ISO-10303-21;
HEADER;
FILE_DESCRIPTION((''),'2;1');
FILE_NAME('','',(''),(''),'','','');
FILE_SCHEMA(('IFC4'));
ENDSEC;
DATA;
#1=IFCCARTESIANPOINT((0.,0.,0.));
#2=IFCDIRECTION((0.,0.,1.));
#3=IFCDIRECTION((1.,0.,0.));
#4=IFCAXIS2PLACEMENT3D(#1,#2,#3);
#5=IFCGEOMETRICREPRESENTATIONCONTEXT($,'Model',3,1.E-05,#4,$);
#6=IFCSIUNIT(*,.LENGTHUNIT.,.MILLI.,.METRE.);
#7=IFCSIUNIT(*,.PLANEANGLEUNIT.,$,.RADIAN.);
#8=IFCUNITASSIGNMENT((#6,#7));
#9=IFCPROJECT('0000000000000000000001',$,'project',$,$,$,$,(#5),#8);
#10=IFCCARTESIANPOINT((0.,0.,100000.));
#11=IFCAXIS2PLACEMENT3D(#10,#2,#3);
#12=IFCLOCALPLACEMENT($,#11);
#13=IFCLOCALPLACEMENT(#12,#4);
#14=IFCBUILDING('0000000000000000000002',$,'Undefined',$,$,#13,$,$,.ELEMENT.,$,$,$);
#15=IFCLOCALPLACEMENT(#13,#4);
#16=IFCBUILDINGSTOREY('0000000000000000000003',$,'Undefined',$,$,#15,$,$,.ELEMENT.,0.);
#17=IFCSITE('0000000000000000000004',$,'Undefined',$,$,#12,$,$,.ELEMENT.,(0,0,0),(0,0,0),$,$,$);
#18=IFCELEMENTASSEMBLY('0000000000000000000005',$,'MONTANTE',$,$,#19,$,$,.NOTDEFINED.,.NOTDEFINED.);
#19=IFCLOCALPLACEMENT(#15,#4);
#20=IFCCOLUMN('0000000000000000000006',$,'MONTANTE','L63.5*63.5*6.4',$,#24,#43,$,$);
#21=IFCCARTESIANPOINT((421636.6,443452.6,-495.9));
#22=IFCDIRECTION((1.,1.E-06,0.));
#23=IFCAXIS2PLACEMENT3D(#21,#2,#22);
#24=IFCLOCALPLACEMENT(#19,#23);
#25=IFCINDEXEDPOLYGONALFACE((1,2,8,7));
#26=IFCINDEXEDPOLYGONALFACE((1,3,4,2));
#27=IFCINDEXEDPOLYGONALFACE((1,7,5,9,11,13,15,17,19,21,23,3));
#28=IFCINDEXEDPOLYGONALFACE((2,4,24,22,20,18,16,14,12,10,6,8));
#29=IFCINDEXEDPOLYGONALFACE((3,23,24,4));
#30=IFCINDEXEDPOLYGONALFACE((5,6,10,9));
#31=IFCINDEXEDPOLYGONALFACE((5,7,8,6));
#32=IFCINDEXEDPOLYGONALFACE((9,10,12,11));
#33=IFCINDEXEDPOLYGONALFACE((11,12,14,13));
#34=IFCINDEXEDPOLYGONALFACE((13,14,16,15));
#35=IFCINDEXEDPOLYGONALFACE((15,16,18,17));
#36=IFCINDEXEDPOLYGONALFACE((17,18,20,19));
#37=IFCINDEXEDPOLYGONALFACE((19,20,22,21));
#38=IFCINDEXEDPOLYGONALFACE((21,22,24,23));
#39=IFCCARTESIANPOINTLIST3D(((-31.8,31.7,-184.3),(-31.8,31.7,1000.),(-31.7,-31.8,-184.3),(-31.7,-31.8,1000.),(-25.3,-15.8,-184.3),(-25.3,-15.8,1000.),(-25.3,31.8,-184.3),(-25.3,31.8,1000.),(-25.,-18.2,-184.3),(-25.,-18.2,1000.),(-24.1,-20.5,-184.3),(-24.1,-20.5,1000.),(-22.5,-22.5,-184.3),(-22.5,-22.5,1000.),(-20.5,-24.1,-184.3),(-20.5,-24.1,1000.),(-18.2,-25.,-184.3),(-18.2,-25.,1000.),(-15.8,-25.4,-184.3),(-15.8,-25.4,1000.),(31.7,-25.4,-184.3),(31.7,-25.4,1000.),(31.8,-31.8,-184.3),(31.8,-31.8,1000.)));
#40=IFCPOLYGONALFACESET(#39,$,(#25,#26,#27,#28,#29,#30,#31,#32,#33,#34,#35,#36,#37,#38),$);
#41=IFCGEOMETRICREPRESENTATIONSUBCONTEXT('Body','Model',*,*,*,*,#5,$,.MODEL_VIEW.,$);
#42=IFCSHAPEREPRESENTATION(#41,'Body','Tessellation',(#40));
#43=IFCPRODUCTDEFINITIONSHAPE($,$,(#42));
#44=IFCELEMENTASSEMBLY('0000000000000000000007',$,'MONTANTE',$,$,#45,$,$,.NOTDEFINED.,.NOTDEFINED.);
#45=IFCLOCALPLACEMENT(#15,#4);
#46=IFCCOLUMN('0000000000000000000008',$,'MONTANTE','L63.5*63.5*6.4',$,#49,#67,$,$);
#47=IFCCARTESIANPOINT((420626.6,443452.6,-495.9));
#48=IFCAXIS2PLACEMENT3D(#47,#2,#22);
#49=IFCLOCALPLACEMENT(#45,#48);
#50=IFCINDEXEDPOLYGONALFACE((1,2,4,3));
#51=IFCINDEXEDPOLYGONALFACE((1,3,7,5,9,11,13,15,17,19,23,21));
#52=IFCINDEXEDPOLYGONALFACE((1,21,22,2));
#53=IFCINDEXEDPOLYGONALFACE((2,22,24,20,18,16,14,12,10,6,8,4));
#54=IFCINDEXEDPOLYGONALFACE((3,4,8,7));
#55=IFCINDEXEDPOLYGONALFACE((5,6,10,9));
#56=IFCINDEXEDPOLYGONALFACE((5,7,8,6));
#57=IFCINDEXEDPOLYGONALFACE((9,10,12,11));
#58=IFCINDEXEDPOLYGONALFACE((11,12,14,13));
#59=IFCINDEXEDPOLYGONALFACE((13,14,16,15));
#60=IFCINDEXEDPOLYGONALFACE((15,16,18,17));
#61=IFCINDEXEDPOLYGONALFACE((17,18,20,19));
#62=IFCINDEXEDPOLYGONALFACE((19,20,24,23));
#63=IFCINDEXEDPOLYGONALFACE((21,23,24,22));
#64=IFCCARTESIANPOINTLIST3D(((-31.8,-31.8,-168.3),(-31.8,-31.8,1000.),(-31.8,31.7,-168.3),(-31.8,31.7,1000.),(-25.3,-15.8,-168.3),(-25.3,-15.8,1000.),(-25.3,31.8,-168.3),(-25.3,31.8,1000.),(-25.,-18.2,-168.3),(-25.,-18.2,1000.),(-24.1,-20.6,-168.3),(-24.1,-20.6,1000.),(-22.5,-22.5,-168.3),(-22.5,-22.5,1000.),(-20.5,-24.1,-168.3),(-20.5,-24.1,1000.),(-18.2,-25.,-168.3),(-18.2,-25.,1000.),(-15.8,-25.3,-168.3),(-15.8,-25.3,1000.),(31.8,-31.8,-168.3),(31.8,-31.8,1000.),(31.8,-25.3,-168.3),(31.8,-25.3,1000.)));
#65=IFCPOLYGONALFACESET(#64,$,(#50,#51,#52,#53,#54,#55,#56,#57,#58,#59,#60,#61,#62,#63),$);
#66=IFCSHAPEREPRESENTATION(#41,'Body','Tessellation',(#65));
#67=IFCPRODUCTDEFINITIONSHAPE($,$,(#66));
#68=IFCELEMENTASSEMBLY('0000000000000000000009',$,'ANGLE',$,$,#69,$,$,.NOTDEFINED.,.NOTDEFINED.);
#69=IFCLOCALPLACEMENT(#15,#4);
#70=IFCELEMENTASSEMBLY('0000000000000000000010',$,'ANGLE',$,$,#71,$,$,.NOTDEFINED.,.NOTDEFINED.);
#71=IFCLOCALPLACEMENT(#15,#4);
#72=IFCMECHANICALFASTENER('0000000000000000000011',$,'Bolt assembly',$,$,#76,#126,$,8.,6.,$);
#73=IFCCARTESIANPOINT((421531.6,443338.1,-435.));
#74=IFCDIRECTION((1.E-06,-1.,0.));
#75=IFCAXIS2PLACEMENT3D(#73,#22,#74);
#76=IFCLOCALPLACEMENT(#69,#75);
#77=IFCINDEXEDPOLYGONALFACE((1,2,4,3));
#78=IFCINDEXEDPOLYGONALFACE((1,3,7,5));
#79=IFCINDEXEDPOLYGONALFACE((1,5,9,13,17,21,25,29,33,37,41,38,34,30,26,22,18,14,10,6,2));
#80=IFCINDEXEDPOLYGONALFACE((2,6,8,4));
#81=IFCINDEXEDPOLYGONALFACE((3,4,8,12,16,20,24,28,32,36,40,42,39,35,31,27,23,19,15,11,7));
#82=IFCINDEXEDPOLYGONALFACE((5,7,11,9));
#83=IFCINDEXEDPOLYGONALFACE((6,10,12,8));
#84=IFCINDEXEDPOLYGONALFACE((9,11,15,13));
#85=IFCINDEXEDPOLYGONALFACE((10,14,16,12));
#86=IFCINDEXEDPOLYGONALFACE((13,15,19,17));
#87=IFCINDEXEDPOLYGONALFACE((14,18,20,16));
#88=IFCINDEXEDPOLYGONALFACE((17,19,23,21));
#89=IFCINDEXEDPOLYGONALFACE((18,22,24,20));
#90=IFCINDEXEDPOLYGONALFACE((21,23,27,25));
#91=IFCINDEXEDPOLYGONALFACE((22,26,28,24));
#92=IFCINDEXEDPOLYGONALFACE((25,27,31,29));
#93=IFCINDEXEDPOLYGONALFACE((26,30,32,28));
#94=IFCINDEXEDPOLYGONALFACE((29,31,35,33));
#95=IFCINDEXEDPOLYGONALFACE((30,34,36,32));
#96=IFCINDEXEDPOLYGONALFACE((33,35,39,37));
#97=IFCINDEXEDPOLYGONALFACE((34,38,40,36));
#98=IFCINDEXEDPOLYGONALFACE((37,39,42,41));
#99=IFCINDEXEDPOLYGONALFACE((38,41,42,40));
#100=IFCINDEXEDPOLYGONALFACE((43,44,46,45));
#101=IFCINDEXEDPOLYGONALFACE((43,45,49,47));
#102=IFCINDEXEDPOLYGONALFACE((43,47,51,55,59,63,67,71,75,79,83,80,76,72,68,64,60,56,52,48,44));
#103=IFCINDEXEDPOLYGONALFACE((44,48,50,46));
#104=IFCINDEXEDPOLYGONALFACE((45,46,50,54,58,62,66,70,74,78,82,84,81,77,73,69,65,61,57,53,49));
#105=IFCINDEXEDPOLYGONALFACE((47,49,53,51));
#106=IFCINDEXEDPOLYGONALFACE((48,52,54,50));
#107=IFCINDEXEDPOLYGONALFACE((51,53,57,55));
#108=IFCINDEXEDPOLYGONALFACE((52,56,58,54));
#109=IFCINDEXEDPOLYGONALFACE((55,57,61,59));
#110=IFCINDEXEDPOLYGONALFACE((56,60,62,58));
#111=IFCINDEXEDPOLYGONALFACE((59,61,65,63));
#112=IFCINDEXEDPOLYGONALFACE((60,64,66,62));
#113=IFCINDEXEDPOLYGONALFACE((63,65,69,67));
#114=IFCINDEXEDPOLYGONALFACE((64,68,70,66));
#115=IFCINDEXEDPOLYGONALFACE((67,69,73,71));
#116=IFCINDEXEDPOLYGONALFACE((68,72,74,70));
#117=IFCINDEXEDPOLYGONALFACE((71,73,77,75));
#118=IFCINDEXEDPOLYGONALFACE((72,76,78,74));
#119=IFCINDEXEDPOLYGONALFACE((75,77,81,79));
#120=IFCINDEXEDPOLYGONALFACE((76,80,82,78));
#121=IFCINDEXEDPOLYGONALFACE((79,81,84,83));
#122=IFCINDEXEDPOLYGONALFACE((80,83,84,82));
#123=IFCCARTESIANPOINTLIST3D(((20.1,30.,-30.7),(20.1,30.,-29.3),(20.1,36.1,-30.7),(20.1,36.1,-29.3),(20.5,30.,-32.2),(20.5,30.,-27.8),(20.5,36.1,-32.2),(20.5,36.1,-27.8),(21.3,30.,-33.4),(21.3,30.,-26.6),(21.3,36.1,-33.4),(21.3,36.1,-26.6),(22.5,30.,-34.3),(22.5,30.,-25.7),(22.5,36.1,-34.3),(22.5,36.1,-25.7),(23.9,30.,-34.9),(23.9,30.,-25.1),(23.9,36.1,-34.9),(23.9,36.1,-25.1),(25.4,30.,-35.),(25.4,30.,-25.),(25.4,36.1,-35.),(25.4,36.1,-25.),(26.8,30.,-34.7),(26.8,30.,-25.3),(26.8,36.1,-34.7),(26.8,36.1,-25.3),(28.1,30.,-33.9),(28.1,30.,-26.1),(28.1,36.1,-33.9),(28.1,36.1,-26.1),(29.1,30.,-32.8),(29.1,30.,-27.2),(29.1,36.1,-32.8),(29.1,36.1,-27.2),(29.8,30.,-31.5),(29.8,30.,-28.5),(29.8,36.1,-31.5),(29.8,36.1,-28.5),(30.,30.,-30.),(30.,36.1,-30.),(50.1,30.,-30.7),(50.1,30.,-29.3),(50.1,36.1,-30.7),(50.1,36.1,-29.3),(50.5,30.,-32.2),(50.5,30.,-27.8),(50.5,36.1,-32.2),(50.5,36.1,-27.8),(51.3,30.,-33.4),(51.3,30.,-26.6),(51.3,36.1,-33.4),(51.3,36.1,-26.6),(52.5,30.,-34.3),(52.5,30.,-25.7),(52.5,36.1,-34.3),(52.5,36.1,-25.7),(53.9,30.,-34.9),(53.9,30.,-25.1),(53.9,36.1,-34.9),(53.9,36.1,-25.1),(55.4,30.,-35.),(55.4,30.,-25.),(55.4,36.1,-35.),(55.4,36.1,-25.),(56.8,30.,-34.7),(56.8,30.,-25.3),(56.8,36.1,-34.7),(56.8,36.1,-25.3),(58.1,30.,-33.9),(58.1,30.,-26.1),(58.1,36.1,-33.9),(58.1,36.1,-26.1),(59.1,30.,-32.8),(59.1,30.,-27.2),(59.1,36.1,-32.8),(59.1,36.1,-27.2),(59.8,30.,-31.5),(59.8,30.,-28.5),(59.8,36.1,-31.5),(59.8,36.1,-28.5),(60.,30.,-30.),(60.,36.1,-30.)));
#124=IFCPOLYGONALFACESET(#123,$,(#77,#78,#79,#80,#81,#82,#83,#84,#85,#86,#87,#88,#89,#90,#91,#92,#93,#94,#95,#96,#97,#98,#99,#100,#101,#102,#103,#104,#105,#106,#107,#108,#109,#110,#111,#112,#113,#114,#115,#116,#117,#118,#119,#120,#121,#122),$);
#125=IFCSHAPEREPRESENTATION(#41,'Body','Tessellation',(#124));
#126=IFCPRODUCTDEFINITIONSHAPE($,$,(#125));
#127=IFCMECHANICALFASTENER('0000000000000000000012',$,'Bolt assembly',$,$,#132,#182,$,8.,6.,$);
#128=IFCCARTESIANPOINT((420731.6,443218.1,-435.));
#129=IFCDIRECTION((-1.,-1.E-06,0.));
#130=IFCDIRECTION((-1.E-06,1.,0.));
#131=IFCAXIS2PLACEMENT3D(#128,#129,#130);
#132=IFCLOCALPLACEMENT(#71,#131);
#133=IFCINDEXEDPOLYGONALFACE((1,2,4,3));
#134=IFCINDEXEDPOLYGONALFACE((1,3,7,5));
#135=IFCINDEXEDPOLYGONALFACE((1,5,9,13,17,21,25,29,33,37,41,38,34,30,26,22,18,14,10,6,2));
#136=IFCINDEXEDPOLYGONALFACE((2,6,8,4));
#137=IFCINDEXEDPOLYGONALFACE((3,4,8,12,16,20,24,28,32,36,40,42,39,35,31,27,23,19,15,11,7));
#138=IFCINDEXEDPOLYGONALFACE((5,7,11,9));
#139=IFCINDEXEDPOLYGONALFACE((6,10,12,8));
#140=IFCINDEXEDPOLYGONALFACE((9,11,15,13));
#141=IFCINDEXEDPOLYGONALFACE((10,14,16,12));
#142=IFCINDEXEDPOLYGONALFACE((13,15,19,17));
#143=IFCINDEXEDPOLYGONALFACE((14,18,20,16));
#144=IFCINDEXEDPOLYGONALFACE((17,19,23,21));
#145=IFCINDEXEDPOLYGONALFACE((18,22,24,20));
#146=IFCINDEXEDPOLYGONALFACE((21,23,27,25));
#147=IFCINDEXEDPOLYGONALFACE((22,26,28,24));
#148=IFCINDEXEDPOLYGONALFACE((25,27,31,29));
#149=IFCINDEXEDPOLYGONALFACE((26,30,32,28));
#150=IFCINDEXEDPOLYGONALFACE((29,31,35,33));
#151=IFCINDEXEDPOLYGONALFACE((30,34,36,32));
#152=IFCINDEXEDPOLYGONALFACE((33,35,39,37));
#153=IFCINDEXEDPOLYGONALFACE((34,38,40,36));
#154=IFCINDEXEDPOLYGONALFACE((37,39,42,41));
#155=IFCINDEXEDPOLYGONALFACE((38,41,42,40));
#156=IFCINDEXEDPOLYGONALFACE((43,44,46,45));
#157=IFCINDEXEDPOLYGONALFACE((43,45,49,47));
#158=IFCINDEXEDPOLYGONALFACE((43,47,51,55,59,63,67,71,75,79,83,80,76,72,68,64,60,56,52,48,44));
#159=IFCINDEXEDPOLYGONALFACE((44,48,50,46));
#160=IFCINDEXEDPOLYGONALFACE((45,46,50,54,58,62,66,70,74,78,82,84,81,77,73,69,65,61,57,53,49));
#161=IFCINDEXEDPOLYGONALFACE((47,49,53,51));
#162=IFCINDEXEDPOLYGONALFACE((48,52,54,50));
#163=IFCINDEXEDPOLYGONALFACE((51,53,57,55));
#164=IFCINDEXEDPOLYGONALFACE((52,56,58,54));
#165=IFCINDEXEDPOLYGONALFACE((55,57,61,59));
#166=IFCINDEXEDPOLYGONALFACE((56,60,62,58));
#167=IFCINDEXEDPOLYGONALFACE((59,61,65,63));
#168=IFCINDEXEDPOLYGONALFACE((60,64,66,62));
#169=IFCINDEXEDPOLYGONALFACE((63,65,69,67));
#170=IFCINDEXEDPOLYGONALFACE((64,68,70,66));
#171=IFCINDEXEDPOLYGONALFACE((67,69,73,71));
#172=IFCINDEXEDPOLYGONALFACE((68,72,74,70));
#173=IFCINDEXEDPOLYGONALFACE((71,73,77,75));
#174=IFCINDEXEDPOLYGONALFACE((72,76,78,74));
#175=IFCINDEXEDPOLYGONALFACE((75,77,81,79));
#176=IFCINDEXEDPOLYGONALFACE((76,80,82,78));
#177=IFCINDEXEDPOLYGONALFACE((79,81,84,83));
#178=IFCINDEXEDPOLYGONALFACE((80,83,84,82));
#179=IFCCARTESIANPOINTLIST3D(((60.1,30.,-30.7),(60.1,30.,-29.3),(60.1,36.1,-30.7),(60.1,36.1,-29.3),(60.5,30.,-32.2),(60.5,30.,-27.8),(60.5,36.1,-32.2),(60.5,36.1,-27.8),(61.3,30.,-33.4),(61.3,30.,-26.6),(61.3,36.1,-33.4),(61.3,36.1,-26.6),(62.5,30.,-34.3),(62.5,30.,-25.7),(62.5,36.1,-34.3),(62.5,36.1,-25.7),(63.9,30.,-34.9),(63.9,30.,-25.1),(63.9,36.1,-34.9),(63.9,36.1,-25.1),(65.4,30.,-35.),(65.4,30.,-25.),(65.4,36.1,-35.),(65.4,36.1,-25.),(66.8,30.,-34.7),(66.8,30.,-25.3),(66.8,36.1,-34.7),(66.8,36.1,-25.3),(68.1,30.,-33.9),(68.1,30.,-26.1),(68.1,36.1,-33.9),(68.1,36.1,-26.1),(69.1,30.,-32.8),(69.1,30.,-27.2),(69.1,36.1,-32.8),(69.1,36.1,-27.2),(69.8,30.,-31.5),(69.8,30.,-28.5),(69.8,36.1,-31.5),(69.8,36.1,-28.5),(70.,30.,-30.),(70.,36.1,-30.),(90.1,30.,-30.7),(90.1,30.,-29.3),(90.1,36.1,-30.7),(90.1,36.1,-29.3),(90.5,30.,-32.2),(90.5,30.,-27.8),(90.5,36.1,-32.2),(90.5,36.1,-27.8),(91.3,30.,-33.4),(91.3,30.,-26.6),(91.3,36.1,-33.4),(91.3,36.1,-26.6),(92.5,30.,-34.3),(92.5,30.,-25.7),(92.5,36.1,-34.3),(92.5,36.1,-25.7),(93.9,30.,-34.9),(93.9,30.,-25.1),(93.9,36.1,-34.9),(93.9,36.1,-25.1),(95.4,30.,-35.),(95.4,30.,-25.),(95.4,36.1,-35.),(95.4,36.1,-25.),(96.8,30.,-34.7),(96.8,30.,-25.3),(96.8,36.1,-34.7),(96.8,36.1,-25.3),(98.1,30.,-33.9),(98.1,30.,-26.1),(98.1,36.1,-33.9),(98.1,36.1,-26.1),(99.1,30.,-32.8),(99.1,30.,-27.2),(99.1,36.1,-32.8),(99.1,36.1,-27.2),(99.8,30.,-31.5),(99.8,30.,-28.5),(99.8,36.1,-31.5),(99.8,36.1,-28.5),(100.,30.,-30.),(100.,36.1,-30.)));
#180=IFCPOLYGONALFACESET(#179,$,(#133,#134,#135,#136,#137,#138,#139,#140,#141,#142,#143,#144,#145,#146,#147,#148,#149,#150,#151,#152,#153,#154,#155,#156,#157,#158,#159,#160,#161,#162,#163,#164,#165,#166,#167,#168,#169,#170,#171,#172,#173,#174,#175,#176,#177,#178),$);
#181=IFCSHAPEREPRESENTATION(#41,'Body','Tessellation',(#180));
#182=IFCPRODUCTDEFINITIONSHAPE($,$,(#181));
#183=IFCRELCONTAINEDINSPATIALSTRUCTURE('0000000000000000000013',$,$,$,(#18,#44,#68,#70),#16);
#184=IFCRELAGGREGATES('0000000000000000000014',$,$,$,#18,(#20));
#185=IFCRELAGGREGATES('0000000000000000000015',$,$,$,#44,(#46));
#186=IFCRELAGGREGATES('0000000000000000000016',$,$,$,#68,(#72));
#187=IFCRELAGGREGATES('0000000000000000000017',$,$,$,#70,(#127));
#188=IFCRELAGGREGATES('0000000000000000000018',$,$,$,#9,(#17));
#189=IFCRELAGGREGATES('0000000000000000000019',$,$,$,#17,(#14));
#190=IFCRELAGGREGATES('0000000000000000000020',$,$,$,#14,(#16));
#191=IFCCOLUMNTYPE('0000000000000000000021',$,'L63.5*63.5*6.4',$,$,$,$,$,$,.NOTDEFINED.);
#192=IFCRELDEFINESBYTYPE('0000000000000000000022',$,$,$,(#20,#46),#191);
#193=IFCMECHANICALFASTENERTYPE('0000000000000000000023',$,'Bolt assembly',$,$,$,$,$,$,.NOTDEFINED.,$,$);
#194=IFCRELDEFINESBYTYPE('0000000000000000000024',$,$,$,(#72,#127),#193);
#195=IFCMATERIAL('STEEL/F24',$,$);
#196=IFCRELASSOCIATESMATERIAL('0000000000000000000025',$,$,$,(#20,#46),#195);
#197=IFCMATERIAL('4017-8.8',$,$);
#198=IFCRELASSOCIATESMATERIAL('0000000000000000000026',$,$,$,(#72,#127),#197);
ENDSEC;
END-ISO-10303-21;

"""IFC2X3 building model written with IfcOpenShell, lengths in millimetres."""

from ifc_helpers import new_model, si_unit, frame, origin_with_axes, origin_2d_with_axis, place, context, subcontext, project, spatial, circle, l_section, extrude, clip, halfspace, source, transform, mapped, material, type_object, element, aggregate, save


model = new_model("IFC2X3")

# Units and contexts
model_context = context("Model", 3, precision=1e-05, world=origin_with_axes())
body_context = subcontext(model_context, "Body", "Model", "MODEL_VIEW")
ifc_project = project(units=[si_unit("LENGTHUNIT", "METRE", prefix="MILLI"), si_unit("PLANEANGLEUNIT", "RADIAN")], contexts=[model_context])

# Site, building, storey
site_placement = place(None, frame((0.0, 0.0, 100000.0), z_axis=(0.0, 0.0, 1.0), x_axis=(1.0, 0.0, 0.0)))
site = spatial("IfcSite", under=ifc_project, at=site_placement, Name="Undefined", CompositionType="ELEMENT", RefLatitude=(0, 0, 0), RefLongitude=(0, 0, 0))
building_placement = place(site_placement, origin_with_axes())
building = spatial("IfcBuilding", under=site, at=building_placement, Name="Undefined", CompositionType="ELEMENT")
storey_placement = place(building_placement, origin_with_axes())
storey = spatial("IfcBuildingStorey", under=building, at=storey_placement, Name="Undefined", CompositionType="ELEMENT", Elevation=0.0)

# Element assemblies, columns
assembly_1_placement = place(storey_placement, origin_with_axes())
assembly_1 = element("IfcElementAssembly", 1, at=assembly_1_placement, inside=storey, Name="MONTANTE", AssemblyPlace="NOTDEFINED", PredefinedType="NOTDEFINED")
ifc_material_1 = material(Name="STEEL/F24")
column_type_1 = type_object("IfcColumnType", Name="L63.5*63.5*6.4", PredefinedType="NOTDEFINED")
column_1_placement = place(assembly_1_placement, frame((421636.6, 443452.6, -495.9), z_axis=(0.0, 0.0, 1.0), x_axis=(1.0, 0.000001, 0.0)))
column_1 = element("IfcColumn", 2, at=column_1_placement, type_object=column_type_1, material=ifc_material_1, Name="MONTANTE", Description="L63.5*63.5*6.4", context=body_context, shape_type="Clipping", body=[
    clip(extrude(l_section(Depth=63.5, Width=63.5, Thickness=6.4, FilletRadius=9.6, at=origin_2d_with_axis()), frame((0.0, 0.0, 1000.0), z_axis=(0.0, 0.0, -1.0), x_axis=(0.0, 1.0, 0.0)), (0.0, 0.0, 1.0), 1184.3), halfspace(frame((0.0, 0.0, -184.3), z_axis=(0.0, 0.0, -1.0), x_axis=(0.0, 1.0, 0.0)), False)),
])
assembly_2_placement = place(storey_placement, origin_with_axes())
assembly_2 = element("IfcElementAssembly", 3, at=assembly_2_placement, inside=storey, Name="MONTANTE", AssemblyPlace="NOTDEFINED", PredefinedType="NOTDEFINED")
column_2_placement = place(assembly_2_placement, frame((420626.6, 443452.6, -495.9), z_axis=(0.0, 0.0, 1.0), x_axis=(1.0, 0.000001, 0.0)))
column_2 = element("IfcColumn", 4, at=column_2_placement, type_object=column_type_1, material=ifc_material_1, Name="MONTANTE", Description="L63.5*63.5*6.4", context=body_context, shape_type="Clipping", body=[
    clip(extrude(l_section(Depth=63.5, Width=63.5, Thickness=6.4, FilletRadius=9.6, at=origin_2d_with_axis()), frame((0.0, 0.0, 1000.0), z_axis=(0.0, 0.0, -1.0), x_axis=(0.0, 1.0, 0.0)), (0.0, 0.0, 1.0), 1168.3), halfspace(frame((0.0, 0.0, -168.3), z_axis=(0.0, 0.0, -1.0), x_axis=(0.0, -1.0, 0.0)), False)),
])

# Element assemblies
assembly_3_placement = place(storey_placement, origin_with_axes())
assembly_3 = element("IfcElementAssembly", 5, at=assembly_3_placement, inside=storey, Name="ANGLE", AssemblyPlace="NOTDEFINED", PredefinedType="NOTDEFINED")
assembly_4_placement = place(storey_placement, origin_with_axes())
assembly_4 = element("IfcElementAssembly", 6, at=assembly_4_placement, inside=storey, Name="ANGLE", AssemblyPlace="NOTDEFINED", PredefinedType="NOTDEFINED")

# Mechanical fasteners
ifc_material_2 = material(Name="4017-8.8")
mechanical_fastener_type = type_object("IfcMechanicalFastenerType", Name="Bolt assembly")
aggregate(assembly_1, [column_1])
aggregate(assembly_2, [column_2])
shared_shape_1 = source(origin_with_axes(), body_context, "Body", "SweptSolid", [
    extrude(circle(Radius=5.0, at=origin_2d_with_axis()), frame((0.0, 30.0, 0.0), z_axis=(0.0, 1.0, 0.0), x_axis=(1.0, 0.0, 0.0)), (0.0, 0.0, 1.0), 6.1),
])
mechanical_fastener_1_placement = place(assembly_3_placement, frame((421531.6, 443338.1, -435.0), z_axis=(1.0, 0.000001, 0.0), x_axis=(0.000001, -1.0, 0.0)))
mechanical_fastener_1 = element("IfcMechanicalFastener", 7, at=mechanical_fastener_1_placement, type_object=mechanical_fastener_type, material=ifc_material_2, Name="Bolt assembly", NominalDiameter=8.0, NominalLength=6.0, context=body_context, shape_type="MappedRepresentation", body=[
    mapped(shared_shape_1, transform((25.0, 0.0, -30.0))),
    mapped(shared_shape_1, transform((55.0, 0.0, -30.0))),
])
aggregate(assembly_3, [mechanical_fastener_1])
mechanical_fastener_2_placement = place(assembly_4_placement, frame((420731.6, 443218.1, -435.0), z_axis=(-1.0, -0.000001, 0.0), x_axis=(-0.000001, 1.0, 0.0)))
mechanical_fastener_2 = element("IfcMechanicalFastener", 8, at=mechanical_fastener_2_placement, type_object=mechanical_fastener_type, material=ifc_material_2, Name="Bolt assembly", NominalDiameter=8.0, NominalLength=6.0, context=body_context, shape_type="MappedRepresentation", body=[
    mapped(shared_shape_1, transform((95.0, 0.0, -30.0))),
    mapped(shared_shape_1, transform((65.0, 0.0, -30.0))),
])
aggregate(assembly_4, [mechanical_fastener_2])

save(model, "model.ifc")
